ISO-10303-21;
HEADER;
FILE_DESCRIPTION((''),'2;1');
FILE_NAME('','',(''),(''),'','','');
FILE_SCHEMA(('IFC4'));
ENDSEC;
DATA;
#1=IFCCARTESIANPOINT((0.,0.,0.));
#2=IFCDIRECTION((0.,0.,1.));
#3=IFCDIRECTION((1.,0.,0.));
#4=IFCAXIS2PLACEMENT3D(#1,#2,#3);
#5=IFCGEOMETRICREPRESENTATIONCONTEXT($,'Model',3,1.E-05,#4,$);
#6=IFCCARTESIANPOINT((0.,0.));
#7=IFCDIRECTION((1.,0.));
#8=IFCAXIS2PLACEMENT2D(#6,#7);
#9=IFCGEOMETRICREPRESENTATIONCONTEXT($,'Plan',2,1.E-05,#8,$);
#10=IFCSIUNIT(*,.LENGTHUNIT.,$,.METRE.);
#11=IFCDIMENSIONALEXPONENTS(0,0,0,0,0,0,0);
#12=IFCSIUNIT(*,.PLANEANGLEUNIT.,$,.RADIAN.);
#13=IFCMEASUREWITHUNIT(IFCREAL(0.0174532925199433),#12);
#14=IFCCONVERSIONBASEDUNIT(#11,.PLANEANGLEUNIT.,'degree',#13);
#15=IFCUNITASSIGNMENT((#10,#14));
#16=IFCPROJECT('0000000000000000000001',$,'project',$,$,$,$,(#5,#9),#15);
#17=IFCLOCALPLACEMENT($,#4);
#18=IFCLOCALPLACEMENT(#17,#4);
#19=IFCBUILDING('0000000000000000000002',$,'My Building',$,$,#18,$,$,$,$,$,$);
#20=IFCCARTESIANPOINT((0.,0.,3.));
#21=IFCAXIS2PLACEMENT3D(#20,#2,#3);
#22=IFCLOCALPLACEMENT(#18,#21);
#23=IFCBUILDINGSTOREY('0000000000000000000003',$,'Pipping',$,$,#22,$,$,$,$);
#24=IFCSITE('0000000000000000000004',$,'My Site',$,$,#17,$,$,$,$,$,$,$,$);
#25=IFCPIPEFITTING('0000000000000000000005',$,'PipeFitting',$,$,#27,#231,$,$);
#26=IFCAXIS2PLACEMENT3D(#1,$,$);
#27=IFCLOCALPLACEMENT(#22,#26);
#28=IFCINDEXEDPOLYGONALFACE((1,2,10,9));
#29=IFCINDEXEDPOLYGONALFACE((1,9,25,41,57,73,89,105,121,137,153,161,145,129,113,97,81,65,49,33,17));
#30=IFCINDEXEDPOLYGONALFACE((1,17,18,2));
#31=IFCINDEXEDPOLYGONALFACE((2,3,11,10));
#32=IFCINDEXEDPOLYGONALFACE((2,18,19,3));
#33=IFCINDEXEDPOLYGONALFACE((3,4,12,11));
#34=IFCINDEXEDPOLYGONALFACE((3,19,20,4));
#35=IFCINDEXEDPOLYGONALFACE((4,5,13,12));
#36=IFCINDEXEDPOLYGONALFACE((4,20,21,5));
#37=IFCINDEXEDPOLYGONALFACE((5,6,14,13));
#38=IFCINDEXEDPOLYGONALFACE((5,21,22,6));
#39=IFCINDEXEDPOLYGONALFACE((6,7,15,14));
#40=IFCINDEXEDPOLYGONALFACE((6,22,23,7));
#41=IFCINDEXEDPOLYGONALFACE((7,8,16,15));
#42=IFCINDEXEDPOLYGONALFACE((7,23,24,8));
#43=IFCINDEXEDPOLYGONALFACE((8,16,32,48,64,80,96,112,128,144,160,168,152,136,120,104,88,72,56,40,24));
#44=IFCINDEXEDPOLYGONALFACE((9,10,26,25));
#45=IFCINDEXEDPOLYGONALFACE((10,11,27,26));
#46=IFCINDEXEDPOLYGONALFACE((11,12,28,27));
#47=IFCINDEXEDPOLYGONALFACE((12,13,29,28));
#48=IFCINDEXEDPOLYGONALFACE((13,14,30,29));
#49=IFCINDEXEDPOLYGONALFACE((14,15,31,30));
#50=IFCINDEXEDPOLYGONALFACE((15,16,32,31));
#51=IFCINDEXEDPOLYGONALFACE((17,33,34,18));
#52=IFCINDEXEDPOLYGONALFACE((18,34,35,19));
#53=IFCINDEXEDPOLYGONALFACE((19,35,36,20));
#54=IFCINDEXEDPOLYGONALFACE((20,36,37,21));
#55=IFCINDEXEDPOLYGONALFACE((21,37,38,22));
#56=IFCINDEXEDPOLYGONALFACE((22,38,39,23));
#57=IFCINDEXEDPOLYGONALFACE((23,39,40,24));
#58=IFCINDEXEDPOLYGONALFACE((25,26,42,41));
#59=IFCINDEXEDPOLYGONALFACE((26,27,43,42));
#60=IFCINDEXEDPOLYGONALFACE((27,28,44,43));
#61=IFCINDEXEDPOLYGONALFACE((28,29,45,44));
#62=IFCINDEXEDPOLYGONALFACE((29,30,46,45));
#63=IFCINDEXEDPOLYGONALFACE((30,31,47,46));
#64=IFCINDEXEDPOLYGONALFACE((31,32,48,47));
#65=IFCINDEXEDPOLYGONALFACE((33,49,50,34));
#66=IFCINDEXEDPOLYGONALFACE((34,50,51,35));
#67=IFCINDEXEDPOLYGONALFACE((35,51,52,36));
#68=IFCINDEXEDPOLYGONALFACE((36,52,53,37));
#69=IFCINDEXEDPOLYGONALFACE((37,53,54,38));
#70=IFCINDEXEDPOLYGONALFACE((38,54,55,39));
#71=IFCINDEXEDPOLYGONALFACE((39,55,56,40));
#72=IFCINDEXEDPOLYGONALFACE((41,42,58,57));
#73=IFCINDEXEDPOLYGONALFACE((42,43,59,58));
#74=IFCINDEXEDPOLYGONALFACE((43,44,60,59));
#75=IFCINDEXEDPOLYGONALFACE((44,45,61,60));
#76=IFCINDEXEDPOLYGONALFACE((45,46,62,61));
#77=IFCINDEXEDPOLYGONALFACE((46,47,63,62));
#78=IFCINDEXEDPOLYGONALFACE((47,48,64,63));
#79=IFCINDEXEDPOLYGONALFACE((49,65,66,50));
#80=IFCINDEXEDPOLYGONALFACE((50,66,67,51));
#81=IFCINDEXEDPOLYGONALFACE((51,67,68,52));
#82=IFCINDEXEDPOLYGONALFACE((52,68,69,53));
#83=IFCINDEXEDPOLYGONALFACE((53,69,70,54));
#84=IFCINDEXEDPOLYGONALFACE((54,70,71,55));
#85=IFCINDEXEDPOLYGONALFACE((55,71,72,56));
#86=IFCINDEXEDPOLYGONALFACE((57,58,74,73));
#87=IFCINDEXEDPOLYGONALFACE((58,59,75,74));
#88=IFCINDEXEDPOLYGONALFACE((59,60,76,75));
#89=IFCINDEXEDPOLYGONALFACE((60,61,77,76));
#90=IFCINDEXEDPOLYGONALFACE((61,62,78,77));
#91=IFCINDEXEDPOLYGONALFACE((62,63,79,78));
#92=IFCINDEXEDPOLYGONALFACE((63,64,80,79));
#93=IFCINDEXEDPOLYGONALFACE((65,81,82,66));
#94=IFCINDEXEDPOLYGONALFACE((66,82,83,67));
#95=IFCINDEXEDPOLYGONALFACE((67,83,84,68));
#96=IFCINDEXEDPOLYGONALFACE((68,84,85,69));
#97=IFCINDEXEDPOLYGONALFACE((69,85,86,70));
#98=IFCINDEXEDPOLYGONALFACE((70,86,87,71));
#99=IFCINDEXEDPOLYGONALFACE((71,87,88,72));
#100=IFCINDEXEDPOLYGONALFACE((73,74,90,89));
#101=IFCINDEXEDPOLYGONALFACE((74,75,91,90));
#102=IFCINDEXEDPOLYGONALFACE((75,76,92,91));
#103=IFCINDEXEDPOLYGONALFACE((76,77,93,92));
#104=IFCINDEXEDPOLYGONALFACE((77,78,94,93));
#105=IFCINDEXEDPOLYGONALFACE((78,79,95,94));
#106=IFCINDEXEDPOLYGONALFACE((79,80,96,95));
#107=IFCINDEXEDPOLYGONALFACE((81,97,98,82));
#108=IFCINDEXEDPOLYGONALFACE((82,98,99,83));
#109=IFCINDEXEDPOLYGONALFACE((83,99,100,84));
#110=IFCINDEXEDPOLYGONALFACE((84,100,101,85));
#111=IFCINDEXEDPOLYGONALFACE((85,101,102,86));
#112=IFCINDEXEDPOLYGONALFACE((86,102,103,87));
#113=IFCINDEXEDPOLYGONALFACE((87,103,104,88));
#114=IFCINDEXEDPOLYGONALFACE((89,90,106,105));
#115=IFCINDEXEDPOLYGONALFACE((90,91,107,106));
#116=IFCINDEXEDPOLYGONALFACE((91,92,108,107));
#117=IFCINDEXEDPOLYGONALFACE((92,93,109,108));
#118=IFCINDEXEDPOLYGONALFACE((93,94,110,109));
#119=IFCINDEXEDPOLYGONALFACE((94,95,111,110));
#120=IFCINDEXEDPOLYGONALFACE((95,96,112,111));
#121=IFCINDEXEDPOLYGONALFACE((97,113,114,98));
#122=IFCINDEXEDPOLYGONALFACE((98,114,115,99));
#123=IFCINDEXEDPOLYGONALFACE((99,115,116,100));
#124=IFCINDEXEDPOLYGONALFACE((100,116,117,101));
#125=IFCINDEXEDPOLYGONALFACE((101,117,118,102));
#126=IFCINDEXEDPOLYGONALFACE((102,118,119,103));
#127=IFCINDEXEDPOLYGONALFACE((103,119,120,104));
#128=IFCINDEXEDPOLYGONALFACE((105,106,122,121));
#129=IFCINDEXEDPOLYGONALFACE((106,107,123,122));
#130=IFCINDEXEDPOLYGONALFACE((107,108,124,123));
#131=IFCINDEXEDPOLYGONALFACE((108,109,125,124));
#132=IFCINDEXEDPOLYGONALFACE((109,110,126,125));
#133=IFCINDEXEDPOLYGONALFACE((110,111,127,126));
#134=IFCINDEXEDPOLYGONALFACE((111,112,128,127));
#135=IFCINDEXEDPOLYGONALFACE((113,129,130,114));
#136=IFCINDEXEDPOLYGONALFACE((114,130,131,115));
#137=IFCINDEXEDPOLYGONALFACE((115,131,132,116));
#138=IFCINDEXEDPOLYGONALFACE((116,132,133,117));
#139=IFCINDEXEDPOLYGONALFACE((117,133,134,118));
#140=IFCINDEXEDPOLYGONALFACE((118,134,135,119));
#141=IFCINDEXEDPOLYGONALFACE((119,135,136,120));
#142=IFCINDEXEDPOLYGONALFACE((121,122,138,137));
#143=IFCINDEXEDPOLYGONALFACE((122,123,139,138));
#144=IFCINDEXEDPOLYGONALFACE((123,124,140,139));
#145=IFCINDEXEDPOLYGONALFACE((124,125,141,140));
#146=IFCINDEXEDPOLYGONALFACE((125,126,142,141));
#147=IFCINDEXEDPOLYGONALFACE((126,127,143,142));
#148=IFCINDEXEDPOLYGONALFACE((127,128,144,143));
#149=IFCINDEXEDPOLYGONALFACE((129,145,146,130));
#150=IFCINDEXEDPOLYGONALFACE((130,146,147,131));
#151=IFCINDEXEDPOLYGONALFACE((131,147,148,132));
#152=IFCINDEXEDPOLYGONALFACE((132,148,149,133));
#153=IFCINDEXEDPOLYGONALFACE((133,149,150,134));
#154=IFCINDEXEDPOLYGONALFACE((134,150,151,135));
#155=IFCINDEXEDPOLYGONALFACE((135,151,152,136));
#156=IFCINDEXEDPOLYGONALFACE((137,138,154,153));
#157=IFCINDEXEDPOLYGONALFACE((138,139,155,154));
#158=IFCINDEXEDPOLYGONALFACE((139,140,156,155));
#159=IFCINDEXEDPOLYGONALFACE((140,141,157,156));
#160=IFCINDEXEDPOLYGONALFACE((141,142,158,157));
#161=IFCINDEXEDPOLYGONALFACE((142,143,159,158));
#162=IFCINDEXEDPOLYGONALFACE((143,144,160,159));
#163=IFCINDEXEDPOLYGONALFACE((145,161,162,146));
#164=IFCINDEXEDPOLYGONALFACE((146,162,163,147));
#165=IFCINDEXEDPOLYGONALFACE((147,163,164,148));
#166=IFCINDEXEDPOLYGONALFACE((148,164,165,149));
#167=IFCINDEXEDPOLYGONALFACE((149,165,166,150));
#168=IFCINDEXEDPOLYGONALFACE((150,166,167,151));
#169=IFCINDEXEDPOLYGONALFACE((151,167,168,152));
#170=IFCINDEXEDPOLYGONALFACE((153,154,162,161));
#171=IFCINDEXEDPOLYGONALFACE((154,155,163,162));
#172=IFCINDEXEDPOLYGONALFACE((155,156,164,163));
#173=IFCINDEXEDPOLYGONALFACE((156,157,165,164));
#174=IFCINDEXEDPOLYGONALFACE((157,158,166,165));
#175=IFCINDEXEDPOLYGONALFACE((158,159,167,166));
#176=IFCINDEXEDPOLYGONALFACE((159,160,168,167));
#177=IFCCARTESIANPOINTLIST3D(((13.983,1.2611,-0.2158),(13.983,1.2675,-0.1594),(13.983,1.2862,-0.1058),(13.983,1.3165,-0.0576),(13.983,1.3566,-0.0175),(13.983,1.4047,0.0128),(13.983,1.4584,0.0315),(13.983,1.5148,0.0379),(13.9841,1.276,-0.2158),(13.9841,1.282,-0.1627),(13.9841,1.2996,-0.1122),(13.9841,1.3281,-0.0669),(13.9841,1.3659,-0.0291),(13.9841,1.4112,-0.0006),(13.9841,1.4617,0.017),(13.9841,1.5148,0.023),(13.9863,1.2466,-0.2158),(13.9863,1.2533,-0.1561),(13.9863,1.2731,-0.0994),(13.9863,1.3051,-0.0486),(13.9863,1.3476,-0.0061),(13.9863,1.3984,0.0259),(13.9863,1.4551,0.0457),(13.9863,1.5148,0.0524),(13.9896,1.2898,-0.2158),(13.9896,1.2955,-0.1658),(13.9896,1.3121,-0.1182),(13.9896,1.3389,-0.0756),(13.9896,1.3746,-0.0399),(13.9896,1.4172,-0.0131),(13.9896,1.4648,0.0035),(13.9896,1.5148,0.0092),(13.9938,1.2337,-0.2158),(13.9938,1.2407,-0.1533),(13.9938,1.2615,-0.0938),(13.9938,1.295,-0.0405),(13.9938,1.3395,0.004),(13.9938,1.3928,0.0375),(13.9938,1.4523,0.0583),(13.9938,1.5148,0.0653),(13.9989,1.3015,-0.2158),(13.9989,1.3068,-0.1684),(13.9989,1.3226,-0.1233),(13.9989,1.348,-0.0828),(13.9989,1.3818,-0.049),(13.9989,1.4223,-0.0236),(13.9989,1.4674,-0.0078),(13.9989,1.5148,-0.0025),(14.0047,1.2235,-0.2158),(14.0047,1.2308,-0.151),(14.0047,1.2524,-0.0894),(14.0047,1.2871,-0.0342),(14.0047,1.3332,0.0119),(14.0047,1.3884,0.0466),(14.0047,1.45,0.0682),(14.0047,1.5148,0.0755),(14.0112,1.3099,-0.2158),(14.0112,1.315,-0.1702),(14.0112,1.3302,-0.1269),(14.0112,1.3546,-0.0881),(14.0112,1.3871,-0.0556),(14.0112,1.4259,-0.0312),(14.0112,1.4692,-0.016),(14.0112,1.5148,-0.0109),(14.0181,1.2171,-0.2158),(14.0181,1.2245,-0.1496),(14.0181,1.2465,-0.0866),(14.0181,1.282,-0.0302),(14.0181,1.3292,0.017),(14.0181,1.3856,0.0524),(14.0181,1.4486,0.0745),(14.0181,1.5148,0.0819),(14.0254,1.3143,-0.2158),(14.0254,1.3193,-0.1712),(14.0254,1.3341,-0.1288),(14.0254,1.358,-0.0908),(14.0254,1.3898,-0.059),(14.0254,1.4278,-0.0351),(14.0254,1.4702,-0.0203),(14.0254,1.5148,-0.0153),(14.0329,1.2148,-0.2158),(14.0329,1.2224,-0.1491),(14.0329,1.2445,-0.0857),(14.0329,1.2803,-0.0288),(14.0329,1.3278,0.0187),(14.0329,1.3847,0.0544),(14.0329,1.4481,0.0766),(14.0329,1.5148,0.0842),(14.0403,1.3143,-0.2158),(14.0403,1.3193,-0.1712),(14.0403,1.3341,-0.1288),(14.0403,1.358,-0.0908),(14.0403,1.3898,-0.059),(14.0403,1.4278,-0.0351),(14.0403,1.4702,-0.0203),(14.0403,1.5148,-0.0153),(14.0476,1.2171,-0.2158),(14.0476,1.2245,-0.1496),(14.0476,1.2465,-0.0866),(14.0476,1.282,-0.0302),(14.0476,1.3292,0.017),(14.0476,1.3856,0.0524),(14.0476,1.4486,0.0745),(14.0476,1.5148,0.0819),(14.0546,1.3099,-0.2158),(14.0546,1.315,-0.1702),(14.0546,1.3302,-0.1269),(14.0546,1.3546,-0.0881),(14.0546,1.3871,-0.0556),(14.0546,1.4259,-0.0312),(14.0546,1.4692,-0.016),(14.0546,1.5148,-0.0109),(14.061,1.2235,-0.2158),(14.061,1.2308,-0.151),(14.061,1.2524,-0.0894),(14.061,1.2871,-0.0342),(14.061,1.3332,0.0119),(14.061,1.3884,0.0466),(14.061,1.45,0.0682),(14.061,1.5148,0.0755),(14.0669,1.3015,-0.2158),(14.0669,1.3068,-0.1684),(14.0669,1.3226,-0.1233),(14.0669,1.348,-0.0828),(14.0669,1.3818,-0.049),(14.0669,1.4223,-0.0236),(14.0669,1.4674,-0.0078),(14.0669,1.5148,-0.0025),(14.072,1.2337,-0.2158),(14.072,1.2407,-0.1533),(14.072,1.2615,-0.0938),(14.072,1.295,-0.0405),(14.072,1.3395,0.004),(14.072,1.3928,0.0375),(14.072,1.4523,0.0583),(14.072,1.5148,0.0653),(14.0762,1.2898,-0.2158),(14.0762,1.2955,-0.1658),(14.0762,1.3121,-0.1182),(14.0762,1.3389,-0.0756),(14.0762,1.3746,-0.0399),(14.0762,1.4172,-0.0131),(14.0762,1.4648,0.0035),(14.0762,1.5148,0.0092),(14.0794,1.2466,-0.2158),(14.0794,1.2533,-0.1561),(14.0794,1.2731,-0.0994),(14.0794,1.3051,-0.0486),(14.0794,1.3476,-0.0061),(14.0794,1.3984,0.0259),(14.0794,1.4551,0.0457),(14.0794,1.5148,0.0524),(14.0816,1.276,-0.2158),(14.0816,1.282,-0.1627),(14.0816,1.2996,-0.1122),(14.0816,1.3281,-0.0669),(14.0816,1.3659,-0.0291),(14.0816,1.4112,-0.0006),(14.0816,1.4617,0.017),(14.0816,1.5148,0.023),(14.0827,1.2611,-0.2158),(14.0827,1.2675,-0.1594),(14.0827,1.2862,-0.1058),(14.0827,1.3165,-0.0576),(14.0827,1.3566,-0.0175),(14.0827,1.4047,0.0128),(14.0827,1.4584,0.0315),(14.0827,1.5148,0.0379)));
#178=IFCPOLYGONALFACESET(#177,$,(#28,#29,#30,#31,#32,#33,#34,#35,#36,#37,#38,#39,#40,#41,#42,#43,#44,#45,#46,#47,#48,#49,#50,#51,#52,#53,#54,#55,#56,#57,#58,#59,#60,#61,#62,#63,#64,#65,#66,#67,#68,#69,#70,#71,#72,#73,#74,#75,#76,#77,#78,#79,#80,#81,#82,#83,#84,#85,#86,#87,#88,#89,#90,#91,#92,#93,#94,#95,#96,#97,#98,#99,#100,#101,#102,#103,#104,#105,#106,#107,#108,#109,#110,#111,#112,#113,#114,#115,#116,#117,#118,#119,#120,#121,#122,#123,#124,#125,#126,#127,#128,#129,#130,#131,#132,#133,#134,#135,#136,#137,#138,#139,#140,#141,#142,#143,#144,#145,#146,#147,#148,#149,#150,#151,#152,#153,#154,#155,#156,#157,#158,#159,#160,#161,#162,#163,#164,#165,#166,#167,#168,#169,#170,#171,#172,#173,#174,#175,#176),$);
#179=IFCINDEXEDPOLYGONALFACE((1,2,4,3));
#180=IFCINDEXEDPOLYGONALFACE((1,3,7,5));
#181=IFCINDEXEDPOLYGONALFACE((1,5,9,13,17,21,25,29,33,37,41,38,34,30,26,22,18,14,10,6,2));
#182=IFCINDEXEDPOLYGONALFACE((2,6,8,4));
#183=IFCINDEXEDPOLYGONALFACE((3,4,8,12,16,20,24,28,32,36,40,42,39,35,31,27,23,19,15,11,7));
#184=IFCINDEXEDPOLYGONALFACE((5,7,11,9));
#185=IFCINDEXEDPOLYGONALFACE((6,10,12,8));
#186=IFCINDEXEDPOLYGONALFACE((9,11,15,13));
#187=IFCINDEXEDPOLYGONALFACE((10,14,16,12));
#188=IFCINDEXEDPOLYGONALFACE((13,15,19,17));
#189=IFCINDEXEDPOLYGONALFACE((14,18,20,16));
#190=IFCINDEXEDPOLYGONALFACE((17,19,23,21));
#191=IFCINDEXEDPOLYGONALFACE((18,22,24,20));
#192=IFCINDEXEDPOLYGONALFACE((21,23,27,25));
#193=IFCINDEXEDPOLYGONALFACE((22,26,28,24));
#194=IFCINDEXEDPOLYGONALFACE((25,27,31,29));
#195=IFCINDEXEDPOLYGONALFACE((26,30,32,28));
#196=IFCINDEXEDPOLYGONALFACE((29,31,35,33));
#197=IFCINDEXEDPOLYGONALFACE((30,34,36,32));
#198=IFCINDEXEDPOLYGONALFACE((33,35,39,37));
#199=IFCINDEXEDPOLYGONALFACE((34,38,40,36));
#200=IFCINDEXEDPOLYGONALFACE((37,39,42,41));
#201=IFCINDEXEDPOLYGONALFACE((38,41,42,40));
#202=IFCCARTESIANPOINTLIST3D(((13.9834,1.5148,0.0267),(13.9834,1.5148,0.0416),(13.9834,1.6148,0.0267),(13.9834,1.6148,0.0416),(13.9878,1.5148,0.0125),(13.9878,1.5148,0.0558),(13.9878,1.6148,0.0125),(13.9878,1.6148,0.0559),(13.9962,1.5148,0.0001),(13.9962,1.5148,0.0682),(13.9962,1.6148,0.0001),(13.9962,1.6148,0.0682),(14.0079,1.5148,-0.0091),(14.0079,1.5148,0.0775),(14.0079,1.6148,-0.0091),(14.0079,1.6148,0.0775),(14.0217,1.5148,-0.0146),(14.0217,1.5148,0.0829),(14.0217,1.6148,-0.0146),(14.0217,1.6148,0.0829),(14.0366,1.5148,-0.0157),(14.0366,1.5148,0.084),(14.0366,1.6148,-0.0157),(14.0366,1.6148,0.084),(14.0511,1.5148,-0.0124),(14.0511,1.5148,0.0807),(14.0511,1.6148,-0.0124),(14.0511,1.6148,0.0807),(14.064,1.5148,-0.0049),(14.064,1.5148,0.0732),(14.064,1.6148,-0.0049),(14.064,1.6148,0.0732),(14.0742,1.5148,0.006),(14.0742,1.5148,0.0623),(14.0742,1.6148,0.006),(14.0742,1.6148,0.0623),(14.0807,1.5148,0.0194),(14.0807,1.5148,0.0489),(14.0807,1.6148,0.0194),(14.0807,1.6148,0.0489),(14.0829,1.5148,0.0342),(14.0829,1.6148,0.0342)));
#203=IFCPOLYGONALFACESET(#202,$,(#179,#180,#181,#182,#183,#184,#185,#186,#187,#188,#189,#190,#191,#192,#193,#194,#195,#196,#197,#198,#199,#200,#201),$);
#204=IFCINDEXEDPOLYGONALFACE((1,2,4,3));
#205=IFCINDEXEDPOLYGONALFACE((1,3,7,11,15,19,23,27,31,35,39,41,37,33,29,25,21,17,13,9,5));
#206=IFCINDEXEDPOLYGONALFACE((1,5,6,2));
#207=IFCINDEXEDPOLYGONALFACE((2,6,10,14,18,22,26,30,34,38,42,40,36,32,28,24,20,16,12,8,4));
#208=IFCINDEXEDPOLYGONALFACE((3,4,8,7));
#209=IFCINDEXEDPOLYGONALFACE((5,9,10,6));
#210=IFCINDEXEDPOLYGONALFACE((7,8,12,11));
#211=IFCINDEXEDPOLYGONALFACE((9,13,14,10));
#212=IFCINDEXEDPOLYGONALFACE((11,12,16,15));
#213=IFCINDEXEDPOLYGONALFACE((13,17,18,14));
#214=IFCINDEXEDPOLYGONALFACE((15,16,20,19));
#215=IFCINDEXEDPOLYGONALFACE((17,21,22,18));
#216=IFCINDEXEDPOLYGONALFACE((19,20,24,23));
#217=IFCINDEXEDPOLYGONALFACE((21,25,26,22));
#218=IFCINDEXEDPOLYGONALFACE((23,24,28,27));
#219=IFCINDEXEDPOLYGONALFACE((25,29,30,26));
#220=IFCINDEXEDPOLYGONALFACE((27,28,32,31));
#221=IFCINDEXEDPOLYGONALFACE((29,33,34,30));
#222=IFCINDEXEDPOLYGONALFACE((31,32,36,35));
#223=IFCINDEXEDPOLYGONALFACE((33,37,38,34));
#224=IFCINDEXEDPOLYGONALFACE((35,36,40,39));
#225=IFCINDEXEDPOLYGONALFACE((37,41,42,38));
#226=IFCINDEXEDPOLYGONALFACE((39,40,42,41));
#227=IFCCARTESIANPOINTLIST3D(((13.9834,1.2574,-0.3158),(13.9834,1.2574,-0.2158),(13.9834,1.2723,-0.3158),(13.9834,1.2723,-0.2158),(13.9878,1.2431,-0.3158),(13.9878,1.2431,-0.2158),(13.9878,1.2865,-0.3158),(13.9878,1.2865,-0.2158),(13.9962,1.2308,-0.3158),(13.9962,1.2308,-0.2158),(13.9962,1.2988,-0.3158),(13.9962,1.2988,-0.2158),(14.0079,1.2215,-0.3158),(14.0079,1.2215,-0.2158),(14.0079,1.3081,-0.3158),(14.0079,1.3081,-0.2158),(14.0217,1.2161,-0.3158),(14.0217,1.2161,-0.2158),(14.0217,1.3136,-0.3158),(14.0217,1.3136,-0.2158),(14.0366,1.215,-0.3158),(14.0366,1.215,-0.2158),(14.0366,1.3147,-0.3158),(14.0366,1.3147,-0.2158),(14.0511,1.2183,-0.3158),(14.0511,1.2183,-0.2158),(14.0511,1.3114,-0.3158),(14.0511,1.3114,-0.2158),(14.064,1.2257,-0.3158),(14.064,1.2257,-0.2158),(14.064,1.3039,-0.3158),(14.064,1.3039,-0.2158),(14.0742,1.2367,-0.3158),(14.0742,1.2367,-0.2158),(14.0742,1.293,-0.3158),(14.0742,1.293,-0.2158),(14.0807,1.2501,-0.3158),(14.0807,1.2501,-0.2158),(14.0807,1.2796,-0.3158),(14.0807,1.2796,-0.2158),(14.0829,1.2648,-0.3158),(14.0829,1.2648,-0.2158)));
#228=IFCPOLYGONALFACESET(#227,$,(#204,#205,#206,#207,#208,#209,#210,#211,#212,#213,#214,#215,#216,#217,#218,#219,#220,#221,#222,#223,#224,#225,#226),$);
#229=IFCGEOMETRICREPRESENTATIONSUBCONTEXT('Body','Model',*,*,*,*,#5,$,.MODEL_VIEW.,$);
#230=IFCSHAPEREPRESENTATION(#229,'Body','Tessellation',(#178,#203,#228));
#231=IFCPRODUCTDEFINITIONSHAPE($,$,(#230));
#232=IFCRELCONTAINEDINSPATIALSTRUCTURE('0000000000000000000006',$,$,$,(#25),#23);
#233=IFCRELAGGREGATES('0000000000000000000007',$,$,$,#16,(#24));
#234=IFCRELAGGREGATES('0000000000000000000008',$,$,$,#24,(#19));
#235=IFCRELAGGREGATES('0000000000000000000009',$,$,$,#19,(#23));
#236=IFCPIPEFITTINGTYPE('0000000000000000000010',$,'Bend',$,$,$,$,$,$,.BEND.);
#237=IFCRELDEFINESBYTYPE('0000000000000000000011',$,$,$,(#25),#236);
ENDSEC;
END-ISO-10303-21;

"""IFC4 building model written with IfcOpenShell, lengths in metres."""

from ifc_helpers import new_model, entity, si_unit, converted_unit, frame, origin_with_axes, origin_2d_with_axis, place, context, subcontext, project, spatial, circle, extrude, source, transform, mapped, type_object, type_shapes, element, save


model = new_model("IFC4")

# Units and contexts
model_context = context("Model", 3, precision=1e-05, world=origin_with_axes())
plan_context = context("Plan", 2, precision=1e-05, world=origin_2d_with_axis())
body_context = subcontext(model_context, "Body", "Model", "MODEL_VIEW")
ifc_project = project(units=[si_unit("LENGTHUNIT", "METRE"), converted_unit("PLANEANGLEUNIT", "degree", entity("IfcReal", 0.0174532925199433), si_unit("PLANEANGLEUNIT", "RADIAN"), dimensions=[0, 0, 0, 0, 0, 0, 0])], contexts=[model_context, plan_context])

# Site, building, storey
site_placement = place(None, origin_with_axes())
site = spatial("IfcSite", under=ifc_project, at=site_placement, Name="My Site")
building_placement = place(site_placement, origin_with_axes())
building = spatial("IfcBuilding", under=site, at=building_placement, Name="My Building")
storey_placement = place(building_placement, frame((0.0, 0.0, 3.0), z_axis=(0.0, 0.0, 1.0), x_axis=(1.0, 0.0, 0.0)))
storey = spatial("IfcBuildingStorey", under=building, at=storey_placement, Name="Pipping")

# Pipe fitting
pipe_fitting_type_1 = type_object("IfcPipeFittingType", Name="Bend", PredefinedType="BEND")
shared_shape_1 = source(origin_with_axes(), body_context, "Body", "SolidModel", [
    entity("IfcSweptDiskSolid", entity("IfcIndexedPolyCurve", entity("IfcCartesianPointList3D", [[0.0, 0.0, 0.1], [0.0, -0.0732, 0.2768], [0.0, -0.25, 0.35]]), [entity("IfcArcIndex", [1, 2, 3])]), 0.05),
    extrude(circle(Radius=0.05), origin_with_axes(), (0.0, 0.0, 1.0), 0.1),
    extrude(circle(Radius=0.05), frame((0.0, -0.25, 0.35), z_axis=(0.0, -1.0, 0.000004), x_axis=(1.0, 0.0, 0.0)), (0.0, 0.0, 1.0), 0.1),
])
type_shapes(pipe_fitting_type_1, [shared_shape_1])
for number, where, z_axis, x_axis, name in (
    (1, (14.0329, 1.6148, 0.0342), (0.0, -1.0, -0.000004), (1.0, 0.0, 0.0), "PipeFitting"),
):
    element("IfcPipeFitting", number, at=place(storey_placement, frame(where, z_axis=z_axis, x_axis=x_axis)), inside=storey, type_object=pipe_fitting_type_1, Name=name, context=body_context, shape_type="MappedRepresentation", body=[
        mapped(shared_shape_1, transform((0.0, 0.0, 0.0), x_axis=(1.0, 0.0, 0.0), y_axis=(0.0, 1.0, 0.0), z_axis=(0.0, 0.0, 1.0), scale=1.0)),
    ])

save(model, "model.ifc")
